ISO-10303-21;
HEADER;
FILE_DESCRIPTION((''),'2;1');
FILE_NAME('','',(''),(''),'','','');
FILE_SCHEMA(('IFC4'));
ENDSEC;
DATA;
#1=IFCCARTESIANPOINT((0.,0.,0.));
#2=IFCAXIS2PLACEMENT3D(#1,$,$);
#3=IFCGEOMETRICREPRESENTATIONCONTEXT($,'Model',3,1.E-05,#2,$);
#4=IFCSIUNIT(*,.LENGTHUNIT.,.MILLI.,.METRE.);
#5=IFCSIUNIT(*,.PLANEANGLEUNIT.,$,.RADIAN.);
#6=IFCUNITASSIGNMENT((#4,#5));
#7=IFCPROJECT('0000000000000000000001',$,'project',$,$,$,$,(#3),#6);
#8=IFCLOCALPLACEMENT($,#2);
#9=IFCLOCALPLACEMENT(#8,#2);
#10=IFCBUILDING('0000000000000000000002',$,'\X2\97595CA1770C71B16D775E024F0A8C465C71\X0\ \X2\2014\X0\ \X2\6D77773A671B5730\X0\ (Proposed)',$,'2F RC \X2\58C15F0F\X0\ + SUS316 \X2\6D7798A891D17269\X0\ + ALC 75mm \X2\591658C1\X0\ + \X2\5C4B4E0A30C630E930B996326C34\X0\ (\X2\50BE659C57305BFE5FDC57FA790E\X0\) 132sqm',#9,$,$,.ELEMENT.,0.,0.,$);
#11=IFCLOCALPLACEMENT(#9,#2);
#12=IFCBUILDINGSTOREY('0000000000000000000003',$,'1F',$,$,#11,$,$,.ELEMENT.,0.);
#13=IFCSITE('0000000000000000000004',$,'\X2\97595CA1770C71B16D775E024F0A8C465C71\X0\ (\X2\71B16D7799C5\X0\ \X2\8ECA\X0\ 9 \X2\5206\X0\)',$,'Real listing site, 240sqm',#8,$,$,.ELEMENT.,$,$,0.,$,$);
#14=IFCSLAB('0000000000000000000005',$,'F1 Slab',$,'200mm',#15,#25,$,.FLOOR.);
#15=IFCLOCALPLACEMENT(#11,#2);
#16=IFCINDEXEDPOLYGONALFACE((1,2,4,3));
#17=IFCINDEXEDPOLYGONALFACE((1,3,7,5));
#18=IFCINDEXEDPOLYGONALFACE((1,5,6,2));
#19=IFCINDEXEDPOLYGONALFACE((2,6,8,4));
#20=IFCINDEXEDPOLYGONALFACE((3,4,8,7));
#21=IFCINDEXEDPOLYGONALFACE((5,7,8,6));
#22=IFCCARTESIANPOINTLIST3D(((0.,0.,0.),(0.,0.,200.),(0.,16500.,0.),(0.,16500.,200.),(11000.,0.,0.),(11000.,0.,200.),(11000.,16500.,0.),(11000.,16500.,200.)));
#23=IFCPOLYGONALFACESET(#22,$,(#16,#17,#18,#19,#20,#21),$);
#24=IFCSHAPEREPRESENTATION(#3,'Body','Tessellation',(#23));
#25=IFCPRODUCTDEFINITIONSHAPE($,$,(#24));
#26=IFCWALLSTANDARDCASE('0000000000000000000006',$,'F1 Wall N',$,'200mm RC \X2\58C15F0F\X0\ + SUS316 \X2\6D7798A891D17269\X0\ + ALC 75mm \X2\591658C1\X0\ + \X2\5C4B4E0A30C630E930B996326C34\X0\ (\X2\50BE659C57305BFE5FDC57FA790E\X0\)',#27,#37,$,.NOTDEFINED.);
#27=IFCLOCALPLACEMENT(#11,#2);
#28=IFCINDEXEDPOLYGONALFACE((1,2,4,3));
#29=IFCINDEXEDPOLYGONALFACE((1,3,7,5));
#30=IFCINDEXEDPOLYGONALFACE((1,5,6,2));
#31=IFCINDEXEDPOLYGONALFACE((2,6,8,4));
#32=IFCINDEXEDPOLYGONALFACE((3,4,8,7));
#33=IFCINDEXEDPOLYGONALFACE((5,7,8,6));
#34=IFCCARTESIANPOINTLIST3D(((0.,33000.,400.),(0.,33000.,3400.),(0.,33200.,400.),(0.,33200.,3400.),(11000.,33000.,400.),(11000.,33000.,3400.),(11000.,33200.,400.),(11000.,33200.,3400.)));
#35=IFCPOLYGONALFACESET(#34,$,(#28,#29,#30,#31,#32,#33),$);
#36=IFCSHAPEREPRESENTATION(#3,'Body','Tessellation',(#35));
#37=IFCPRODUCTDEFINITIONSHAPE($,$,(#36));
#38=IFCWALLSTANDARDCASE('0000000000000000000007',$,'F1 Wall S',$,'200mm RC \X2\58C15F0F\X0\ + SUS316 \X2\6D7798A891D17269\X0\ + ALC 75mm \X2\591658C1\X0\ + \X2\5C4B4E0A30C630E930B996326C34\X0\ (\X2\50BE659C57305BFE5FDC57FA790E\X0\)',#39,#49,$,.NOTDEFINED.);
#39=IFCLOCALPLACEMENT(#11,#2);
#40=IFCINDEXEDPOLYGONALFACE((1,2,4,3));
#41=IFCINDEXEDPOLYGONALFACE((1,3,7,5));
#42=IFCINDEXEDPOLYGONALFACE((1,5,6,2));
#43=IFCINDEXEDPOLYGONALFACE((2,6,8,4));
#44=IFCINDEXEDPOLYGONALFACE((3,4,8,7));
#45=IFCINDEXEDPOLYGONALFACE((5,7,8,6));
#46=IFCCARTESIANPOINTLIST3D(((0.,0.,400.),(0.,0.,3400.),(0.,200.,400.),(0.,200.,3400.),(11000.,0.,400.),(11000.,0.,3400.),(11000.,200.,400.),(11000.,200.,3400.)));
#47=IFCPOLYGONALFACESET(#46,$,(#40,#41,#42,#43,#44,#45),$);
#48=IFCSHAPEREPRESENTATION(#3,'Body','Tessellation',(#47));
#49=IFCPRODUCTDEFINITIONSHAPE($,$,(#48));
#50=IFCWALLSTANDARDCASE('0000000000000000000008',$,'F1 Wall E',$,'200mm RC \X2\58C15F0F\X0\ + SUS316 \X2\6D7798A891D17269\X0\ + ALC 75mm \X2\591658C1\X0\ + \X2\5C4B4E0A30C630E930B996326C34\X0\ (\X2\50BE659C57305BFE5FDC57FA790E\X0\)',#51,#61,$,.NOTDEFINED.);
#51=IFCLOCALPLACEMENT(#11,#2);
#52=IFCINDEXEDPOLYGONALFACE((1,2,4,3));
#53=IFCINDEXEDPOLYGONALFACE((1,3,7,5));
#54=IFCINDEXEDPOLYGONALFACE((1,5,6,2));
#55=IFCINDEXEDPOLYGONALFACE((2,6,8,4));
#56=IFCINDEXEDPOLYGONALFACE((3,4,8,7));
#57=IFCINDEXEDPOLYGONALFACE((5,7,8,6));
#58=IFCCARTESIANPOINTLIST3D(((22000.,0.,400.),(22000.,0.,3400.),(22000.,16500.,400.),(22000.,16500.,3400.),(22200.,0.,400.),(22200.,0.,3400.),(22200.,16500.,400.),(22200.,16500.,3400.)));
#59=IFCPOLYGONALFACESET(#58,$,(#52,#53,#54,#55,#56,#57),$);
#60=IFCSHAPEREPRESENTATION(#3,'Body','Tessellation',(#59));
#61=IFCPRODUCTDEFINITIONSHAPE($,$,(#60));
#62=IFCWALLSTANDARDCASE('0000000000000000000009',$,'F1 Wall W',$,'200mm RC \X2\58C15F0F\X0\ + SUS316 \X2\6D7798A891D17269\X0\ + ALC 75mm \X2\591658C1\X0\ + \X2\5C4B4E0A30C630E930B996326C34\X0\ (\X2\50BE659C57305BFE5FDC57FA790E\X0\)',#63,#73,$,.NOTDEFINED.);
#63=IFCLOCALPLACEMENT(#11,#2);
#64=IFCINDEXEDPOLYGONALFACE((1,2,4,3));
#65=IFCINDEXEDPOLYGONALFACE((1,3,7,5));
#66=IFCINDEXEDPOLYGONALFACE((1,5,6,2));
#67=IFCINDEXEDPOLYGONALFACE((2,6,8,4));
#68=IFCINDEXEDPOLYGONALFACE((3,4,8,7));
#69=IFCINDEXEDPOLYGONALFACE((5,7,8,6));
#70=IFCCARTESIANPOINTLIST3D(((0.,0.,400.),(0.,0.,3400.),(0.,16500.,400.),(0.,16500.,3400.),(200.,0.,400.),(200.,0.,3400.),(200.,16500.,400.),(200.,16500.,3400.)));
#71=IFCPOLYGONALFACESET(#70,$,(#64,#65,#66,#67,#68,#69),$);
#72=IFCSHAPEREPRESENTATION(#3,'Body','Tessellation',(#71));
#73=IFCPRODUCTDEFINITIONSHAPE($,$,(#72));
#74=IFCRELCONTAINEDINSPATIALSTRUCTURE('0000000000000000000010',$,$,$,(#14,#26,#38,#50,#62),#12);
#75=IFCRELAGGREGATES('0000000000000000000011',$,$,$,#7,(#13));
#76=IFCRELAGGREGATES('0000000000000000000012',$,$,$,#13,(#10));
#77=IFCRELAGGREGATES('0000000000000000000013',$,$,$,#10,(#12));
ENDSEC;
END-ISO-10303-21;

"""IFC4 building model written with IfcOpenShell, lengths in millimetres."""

from ifc_helpers import new_model, si_unit, frame, frame_2d, origin, place, context, project, spatial, rectangle, extrude, element, save


model = new_model("IFC4")

# Units and contexts
model_context = context("Model", 3, precision=1e-05, world=origin())
ifc_project = project(units=[si_unit("LENGTHUNIT", "METRE", prefix="MILLI"), si_unit("PLANEANGLEUNIT", "RADIAN")], contexts=[model_context])

# Site, building, storey
site_placement = place(None, origin())
site = spatial("IfcSite", under=ifc_project, at=site_placement, Name="静岡県熱海市伊豆山 (熱海駅 車 9 分)", ObjectType="Real listing site, 240sqm", CompositionType="ELEMENT", RefElevation=0.0)
building_placement = place(site_placement, origin())
building = spatial("IfcBuilding", under=site, at=building_placement, Name="静岡県熱海市伊豆山 — 海眺望地 (Proposed)", ObjectType="2F RC 壁式 + SUS316 海風金物 + ALC 75mm 外壁 + 屋上テラス防水 (傾斜地対応基礎) 132sqm", CompositionType="ELEMENT", ElevationOfRefHeight=0.0, ElevationOfTerrain=0.0)
storey_placement = place(building_placement, origin())
storey = spatial("IfcBuildingStorey", under=building, at=storey_placement, Name="1F", CompositionType="ELEMENT", Elevation=0.0)

# Slab
slab_placement = place(storey_placement, origin())
element("IfcSlab", 1, at=slab_placement, inside=storey, Name="F1 Slab", ObjectType="200mm", PredefinedType="FLOOR", context=model_context, shape_type="SweptSolid", body=[
    extrude(rectangle(XDim=11000.0, YDim=16500.0, at=frame_2d((5500.0, 8250.0))), origin(), (0.0, 0.0, 1.0), 200.0),
])

# Walls
wall_1_placement = place(storey_placement, frame((0.0, 16500.0, 200.0)))
element("IfcWallStandardCase", 2, at=wall_1_placement, inside=storey, Name="F1 Wall N", ObjectType="200mm RC 壁式 + SUS316 海風金物 + ALC 75mm 外壁 + 屋上テラス防水 (傾斜地対応基礎)", PredefinedType="NOTDEFINED", context=model_context, shape_type="SweptSolid", body=[
    extrude(rectangle(XDim=11000.0, YDim=200.0, at=frame_2d((5500.0, 100.0))), frame((0.0, 16500.0, 200.0)), (0.0, 0.0, 1.0), 3000.0),
])
wall_2_placement = place(storey_placement, frame((0.0, 0.0, 200.0)))
element("IfcWallStandardCase", 3, at=wall_2_placement, inside=storey, Name="F1 Wall S", ObjectType="200mm RC 壁式 + SUS316 海風金物 + ALC 75mm 外壁 + 屋上テラス防水 (傾斜地対応基礎)", PredefinedType="NOTDEFINED", context=model_context, shape_type="SweptSolid", body=[
    extrude(rectangle(XDim=11000.0, YDim=200.0, at=frame_2d((5500.0, 100.0))), frame((0.0, 0.0, 200.0)), (0.0, 0.0, 1.0), 3000.0),
])
wall_3_placement = place(storey_placement, frame((11000.0, 0.0, 200.0)))
element("IfcWallStandardCase", 4, at=wall_3_placement, inside=storey, Name="F1 Wall E", ObjectType="200mm RC 壁式 + SUS316 海風金物 + ALC 75mm 外壁 + 屋上テラス防水 (傾斜地対応基礎)", PredefinedType="NOTDEFINED", context=model_context, shape_type="SweptSolid", body=[
    extrude(rectangle(XDim=200.0, YDim=16500.0, at=frame_2d((100.0, 8250.0))), frame((11000.0, 0.0, 200.0)), (0.0, 0.0, 1.0), 3000.0),
])
wall_4_placement = place(storey_placement, frame((0.0, 0.0, 200.0)))
element("IfcWallStandardCase", 5, at=wall_4_placement, inside=storey, Name="F1 Wall W", ObjectType="200mm RC 壁式 + SUS316 海風金物 + ALC 75mm 外壁 + 屋上テラス防水 (傾斜地対応基礎)", PredefinedType="NOTDEFINED", context=model_context, shape_type="SweptSolid", body=[
    extrude(rectangle(XDim=200.0, YDim=16500.0, at=frame_2d((100.0, 8250.0))), frame((0.0, 0.0, 200.0)), (0.0, 0.0, 1.0), 3000.0),
])

save(model, "model.ifc")
